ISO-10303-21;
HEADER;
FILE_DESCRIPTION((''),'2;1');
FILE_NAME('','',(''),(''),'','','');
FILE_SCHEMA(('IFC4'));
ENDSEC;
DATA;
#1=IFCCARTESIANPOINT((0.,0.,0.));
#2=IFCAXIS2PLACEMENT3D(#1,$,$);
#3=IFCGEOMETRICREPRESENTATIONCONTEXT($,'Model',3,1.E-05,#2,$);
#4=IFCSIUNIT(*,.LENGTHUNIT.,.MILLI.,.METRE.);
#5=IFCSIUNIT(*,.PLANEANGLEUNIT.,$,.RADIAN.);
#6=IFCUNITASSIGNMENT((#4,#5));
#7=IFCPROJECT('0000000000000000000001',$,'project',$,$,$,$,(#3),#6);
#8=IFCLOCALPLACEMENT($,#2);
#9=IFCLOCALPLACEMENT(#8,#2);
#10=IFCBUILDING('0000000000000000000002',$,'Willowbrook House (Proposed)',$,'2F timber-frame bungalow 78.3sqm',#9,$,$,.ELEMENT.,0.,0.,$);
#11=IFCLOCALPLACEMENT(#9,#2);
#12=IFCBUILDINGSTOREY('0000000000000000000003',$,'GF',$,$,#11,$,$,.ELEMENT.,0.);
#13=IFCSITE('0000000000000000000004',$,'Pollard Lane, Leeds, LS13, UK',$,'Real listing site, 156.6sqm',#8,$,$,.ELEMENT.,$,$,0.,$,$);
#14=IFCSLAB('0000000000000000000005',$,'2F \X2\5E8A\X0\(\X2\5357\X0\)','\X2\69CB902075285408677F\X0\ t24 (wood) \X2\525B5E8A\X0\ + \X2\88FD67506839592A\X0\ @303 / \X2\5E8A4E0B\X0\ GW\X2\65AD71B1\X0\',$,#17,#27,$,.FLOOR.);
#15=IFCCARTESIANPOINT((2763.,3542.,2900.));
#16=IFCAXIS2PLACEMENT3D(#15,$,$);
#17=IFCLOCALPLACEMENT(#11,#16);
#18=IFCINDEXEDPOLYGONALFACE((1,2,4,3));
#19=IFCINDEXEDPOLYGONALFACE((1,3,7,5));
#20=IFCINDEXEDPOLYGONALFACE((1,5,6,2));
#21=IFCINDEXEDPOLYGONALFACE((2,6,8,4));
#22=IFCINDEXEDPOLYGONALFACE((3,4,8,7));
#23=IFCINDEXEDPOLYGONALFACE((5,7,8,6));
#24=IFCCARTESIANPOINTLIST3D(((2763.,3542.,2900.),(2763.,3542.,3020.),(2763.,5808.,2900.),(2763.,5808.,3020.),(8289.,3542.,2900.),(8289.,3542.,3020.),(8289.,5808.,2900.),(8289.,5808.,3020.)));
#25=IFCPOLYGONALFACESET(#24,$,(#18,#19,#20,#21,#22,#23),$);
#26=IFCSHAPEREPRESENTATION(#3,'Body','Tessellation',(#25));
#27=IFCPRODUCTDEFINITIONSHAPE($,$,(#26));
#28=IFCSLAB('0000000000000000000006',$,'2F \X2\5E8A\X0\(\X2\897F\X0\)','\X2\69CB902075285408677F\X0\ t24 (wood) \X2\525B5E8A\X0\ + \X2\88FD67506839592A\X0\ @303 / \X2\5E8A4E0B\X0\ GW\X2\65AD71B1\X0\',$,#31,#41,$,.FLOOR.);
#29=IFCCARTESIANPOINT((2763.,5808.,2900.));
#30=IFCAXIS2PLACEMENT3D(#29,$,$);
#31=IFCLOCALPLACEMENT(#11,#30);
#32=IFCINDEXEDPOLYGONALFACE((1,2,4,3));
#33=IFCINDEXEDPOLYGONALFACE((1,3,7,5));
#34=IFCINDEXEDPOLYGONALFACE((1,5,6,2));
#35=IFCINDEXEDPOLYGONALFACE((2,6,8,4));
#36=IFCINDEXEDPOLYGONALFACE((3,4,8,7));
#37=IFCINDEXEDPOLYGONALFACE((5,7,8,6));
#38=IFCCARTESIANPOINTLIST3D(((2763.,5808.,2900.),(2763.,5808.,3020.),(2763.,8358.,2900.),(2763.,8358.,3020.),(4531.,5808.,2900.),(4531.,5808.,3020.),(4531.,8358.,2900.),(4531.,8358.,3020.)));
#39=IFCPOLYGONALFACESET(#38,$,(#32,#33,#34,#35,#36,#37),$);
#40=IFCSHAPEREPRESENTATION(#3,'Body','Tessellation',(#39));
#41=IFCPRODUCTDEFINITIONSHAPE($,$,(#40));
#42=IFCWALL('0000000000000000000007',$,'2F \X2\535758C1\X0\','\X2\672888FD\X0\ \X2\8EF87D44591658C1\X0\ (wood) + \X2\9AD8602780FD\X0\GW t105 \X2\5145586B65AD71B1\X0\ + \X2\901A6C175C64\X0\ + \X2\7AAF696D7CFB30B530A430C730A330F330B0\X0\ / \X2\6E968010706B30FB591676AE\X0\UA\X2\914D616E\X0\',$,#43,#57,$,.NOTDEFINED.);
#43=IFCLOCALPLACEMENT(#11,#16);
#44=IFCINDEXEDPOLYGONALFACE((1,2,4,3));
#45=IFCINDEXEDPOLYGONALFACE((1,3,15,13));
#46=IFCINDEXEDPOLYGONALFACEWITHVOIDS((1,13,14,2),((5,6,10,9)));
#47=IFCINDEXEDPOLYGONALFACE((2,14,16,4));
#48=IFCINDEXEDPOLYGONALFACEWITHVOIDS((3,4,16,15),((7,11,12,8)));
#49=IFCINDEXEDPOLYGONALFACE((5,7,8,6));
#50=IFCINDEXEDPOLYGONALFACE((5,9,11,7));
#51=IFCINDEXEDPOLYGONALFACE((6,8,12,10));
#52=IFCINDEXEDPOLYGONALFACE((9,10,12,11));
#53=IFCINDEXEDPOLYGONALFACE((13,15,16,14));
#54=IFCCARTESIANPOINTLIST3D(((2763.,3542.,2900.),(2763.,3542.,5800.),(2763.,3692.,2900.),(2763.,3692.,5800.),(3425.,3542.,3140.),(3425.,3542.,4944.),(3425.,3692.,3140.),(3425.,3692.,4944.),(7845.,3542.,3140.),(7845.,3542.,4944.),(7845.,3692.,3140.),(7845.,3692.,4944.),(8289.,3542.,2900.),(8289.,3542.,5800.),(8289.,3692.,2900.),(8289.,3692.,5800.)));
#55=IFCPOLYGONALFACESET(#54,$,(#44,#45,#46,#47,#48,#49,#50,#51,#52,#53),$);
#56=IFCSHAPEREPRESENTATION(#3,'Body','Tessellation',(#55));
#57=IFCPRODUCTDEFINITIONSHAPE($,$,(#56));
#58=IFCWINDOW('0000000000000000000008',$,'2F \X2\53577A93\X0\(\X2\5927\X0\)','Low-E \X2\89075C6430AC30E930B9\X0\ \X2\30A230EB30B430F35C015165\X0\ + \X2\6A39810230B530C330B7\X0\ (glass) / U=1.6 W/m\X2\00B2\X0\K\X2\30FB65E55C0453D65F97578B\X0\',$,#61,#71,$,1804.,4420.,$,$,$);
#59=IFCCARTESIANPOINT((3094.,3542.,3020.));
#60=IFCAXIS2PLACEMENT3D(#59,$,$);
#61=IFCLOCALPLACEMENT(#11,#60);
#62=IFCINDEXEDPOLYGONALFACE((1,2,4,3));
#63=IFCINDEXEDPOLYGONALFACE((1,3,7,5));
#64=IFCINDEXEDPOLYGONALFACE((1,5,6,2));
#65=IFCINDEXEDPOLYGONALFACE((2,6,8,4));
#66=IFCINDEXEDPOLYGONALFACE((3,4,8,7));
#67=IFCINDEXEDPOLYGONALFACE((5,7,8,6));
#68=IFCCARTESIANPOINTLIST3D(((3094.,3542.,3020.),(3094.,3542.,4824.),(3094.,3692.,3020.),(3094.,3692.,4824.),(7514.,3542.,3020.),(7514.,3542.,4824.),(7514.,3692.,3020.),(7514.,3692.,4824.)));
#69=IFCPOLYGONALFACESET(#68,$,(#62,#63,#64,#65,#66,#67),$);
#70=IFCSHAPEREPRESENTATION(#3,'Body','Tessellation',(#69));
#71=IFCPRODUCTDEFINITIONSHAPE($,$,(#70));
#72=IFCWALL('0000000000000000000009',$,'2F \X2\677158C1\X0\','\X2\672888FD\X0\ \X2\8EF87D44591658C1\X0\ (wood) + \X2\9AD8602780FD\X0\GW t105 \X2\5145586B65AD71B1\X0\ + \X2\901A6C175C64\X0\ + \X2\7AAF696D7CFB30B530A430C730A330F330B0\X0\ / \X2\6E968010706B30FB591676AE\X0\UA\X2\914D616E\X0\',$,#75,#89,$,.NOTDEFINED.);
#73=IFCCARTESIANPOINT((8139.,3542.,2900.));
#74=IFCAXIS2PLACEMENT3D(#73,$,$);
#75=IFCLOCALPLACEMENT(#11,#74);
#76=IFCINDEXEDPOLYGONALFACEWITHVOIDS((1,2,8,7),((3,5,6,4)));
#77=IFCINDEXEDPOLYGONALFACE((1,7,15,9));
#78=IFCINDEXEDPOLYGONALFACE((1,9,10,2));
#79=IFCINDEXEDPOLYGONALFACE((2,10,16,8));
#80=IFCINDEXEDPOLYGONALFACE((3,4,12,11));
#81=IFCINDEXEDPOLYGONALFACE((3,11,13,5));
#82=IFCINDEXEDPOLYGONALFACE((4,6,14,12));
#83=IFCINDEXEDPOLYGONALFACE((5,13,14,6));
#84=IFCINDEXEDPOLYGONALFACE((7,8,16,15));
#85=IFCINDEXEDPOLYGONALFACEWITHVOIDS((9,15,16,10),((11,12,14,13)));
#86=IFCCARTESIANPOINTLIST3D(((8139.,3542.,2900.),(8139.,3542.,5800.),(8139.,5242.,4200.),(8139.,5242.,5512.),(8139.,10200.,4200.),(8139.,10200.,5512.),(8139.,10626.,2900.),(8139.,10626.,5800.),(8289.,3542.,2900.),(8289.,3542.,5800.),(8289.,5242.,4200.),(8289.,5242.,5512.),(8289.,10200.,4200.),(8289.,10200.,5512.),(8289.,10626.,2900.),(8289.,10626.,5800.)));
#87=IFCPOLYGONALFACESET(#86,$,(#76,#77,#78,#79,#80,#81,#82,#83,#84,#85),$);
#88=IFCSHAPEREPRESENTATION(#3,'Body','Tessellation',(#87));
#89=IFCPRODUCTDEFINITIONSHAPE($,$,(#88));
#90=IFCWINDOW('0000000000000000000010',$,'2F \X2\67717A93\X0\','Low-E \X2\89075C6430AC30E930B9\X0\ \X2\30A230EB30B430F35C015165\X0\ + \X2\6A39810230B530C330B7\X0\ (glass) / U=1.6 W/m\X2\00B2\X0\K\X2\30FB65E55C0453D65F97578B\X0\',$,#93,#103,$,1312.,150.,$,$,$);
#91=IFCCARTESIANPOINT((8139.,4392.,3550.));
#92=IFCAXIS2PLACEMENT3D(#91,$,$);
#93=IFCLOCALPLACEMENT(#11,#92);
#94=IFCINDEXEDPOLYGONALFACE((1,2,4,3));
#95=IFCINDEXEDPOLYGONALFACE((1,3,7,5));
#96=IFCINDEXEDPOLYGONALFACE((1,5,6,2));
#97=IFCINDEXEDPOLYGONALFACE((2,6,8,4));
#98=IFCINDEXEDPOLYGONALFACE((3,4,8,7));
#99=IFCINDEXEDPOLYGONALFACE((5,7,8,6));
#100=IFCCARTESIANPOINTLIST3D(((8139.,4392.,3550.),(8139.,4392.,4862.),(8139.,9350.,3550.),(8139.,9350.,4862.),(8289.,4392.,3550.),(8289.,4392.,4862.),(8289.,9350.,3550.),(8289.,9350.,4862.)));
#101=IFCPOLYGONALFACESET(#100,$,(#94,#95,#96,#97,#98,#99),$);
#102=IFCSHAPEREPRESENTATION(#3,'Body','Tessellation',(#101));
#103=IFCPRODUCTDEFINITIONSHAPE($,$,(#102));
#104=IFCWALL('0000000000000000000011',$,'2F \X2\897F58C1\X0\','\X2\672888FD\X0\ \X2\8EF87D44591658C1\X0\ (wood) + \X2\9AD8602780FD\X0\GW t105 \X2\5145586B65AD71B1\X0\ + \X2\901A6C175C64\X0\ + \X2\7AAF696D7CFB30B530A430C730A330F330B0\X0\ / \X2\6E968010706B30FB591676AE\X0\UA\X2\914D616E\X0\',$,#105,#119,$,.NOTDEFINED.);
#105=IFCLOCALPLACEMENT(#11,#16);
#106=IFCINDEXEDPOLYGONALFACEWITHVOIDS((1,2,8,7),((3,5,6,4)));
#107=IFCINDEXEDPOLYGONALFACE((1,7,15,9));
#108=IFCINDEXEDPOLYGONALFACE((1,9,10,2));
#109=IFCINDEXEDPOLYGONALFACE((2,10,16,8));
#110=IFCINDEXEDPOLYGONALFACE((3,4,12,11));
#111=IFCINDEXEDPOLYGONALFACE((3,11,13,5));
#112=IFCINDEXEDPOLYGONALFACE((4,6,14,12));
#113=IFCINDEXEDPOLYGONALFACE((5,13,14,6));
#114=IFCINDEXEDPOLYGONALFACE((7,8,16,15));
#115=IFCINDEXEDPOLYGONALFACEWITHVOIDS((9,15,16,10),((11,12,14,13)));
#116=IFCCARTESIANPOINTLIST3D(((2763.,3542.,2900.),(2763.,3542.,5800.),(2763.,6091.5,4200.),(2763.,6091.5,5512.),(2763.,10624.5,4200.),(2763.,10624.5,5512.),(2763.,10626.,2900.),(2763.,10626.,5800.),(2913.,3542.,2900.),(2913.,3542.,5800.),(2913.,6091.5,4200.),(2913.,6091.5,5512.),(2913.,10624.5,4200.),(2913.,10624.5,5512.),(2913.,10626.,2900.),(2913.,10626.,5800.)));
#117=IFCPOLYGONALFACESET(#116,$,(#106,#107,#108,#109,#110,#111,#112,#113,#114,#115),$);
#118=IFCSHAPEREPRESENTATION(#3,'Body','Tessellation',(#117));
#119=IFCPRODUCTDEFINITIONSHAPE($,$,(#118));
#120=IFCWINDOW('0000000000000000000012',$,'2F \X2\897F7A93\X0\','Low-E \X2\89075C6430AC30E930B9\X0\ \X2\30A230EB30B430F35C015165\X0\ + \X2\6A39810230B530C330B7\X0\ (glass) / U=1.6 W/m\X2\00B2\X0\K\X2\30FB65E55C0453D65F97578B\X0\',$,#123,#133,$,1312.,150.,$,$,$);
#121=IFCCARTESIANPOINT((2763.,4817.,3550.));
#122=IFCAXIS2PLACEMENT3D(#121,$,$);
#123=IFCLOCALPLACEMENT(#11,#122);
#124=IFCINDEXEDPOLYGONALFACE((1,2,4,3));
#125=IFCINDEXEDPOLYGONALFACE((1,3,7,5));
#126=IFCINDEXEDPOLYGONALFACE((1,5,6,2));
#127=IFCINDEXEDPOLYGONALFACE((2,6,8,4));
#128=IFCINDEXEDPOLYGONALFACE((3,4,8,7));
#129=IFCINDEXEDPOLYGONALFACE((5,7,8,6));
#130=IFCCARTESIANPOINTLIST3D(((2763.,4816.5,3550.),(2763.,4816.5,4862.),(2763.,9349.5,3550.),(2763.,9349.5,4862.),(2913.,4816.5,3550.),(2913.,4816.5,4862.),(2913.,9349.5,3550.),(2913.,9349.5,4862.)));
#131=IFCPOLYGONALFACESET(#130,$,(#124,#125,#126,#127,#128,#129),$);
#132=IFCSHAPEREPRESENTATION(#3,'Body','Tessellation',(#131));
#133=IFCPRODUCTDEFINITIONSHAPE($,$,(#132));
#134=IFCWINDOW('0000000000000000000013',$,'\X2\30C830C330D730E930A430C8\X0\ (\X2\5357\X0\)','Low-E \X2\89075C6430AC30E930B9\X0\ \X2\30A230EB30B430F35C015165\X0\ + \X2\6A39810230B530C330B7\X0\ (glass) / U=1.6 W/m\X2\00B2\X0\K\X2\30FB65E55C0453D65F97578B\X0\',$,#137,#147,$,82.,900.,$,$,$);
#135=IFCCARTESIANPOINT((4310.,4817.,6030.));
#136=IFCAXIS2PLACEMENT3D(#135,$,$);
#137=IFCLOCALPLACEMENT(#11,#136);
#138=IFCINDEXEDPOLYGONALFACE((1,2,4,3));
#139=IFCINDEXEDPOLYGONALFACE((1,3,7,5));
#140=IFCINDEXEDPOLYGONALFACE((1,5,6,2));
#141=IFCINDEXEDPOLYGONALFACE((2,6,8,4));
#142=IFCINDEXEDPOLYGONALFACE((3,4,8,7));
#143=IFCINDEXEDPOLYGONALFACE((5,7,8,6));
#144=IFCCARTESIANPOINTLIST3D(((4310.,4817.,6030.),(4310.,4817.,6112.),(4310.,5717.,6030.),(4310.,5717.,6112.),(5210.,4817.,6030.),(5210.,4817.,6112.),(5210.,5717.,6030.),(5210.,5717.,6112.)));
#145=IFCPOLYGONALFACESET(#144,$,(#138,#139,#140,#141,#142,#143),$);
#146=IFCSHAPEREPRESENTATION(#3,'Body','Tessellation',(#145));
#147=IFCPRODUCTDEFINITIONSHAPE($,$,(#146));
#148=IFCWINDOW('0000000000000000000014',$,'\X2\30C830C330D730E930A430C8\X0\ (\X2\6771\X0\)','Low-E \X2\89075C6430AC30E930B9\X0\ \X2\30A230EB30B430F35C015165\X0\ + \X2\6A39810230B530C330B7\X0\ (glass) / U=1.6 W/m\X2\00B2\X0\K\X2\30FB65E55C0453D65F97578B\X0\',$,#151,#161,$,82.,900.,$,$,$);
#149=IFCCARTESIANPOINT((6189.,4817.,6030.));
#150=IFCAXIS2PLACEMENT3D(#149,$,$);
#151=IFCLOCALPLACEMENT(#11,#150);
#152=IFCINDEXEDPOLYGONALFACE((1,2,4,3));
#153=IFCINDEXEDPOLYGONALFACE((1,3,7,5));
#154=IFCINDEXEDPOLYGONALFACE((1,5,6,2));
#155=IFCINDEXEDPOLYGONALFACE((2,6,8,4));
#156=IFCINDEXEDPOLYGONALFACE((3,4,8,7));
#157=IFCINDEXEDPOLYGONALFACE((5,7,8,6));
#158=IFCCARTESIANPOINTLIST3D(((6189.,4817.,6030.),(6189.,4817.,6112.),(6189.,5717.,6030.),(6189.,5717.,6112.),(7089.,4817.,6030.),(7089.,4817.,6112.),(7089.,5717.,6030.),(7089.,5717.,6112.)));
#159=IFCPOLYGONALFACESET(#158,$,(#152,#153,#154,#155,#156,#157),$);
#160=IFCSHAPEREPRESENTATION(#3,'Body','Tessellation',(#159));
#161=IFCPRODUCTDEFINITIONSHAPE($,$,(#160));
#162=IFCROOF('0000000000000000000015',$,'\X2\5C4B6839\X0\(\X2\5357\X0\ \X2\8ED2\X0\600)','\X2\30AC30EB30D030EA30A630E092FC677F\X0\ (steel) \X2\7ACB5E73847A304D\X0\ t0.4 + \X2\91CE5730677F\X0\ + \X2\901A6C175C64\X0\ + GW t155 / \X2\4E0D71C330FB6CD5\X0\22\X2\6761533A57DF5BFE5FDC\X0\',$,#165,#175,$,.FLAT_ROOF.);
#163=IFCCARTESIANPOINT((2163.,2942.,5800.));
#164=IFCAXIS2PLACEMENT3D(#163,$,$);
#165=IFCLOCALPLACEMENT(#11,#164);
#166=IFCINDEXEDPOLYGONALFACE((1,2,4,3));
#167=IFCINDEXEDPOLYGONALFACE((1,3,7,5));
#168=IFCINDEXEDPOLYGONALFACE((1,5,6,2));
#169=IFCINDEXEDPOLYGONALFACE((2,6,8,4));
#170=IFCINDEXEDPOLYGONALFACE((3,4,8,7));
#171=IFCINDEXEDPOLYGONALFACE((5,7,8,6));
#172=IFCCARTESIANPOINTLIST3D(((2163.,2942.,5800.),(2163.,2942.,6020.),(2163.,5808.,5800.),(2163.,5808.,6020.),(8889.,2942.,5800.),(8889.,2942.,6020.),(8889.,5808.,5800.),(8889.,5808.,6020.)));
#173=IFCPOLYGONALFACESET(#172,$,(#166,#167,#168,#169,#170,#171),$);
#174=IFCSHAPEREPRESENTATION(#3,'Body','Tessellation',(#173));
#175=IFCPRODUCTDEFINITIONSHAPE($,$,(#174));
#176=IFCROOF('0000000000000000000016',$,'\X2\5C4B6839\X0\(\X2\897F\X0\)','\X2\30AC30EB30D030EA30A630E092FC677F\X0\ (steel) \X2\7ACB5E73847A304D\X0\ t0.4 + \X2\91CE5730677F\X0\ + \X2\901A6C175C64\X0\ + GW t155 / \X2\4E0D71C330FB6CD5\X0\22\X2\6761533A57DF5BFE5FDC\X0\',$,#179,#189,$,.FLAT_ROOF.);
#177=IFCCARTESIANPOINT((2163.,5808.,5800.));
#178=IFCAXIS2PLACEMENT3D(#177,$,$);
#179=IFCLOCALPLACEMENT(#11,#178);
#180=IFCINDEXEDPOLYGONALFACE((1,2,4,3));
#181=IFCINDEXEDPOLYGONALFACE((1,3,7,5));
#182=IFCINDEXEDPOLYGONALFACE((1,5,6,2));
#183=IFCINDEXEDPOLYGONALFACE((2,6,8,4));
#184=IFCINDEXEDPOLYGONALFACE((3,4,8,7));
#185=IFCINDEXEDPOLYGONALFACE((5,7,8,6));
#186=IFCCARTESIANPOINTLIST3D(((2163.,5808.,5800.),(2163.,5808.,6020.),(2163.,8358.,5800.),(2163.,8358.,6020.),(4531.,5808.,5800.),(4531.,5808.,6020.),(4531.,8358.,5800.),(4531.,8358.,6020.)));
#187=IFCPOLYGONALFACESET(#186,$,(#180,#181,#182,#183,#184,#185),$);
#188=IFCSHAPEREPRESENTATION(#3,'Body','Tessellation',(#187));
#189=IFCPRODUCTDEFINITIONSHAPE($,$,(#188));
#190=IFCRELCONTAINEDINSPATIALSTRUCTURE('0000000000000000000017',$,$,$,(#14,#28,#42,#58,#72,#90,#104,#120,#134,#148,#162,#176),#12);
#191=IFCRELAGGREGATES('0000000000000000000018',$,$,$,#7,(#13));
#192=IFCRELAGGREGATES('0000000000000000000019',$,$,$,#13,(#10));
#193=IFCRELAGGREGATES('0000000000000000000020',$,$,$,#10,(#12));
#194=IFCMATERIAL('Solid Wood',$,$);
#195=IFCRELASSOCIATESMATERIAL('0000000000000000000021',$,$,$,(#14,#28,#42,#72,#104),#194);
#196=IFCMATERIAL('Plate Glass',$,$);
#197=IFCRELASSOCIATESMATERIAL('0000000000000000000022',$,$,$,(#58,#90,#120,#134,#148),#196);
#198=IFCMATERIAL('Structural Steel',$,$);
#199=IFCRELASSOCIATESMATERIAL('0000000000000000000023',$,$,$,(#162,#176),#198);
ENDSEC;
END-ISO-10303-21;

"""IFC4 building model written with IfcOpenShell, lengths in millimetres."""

from ifc_helpers import new_model, si_unit, frame, frame_2d, origin, place, context, project, spatial, rectangle, extrude, material, element, fill, save


model = new_model("IFC4")

# Units and contexts
model_context = context("Model", 3, precision=1e-05, world=origin())
ifc_project = project(units=[si_unit("LENGTHUNIT", "METRE", prefix="MILLI"), si_unit("PLANEANGLEUNIT", "RADIAN")], contexts=[model_context])

# Site, building, storey
site_placement = place(None, origin())
site = spatial("IfcSite", under=ifc_project, at=site_placement, Name="Pollard Lane, Leeds, LS13, UK", ObjectType="Real listing site, 156.6sqm", CompositionType="ELEMENT", RefElevation=0.0)
building_placement = place(site_placement, origin())
building = spatial("IfcBuilding", under=site, at=building_placement, Name="Willowbrook House (Proposed)", ObjectType="2F timber-frame bungalow 78.3sqm", CompositionType="ELEMENT", ElevationOfRefHeight=0.0, ElevationOfTerrain=0.0)
storey_placement = place(building_placement, origin())
storey = spatial("IfcBuildingStorey", under=building, at=storey_placement, Name="GF", CompositionType="ELEMENT", Elevation=0.0)

# Slabs
ifc_material_1 = material(Name="Solid Wood")
slab_1_placement = place(storey_placement, frame((2763.0, 3542.0, 2900.0)))
element("IfcSlab", 1, at=slab_1_placement, inside=storey, material=ifc_material_1, Name="2F 床(南)", Description="構造用合板 t24 (wood) 剛床 + 製材根太 @303 / 床下 GW断熱", PredefinedType="FLOOR", context=model_context, shape_type="SweptSolid", body=[
    extrude(rectangle(XDim=5526.0, YDim=2266.0, at=frame_2d((2763.0, 1133.0))), frame((2763.0, 3542.0, 2900.0)), (0.0, 0.0, 1.0), 120.0),
])
slab_2_placement = place(storey_placement, frame((2763.0, 5808.0, 2900.0)))
element("IfcSlab", 2, at=slab_2_placement, inside=storey, material=ifc_material_1, Name="2F 床(西)", Description="構造用合板 t24 (wood) 剛床 + 製材根太 @303 / 床下 GW断熱", PredefinedType="FLOOR", context=model_context, shape_type="SweptSolid", body=[
    extrude(rectangle(XDim=1768.0, YDim=2550.0, at=frame_2d((884.0, 1275.0))), frame((2763.0, 5808.0, 2900.0)), (0.0, 0.0, 1.0), 120.0),
])

# Walls, openings, windows
wall_1_placement = place(storey_placement, frame((2763.0, 3542.0, 2900.0)))
wall_1 = element("IfcWall", 3, at=wall_1_placement, inside=storey, material=ifc_material_1, Name="2F 南壁", Description="木製 軸組外壁 (wood) + 高性能GW t105 充填断熱 + 通気層 + 窯業系サイディング / 準耐火・外皮UA配慮", PredefinedType="NOTDEFINED", context=model_context, shape_type="SweptSolid", body=[
    extrude(rectangle(XDim=5526.0, YDim=150.0, at=frame_2d((2763.0, 75.0))), frame((2763.0, 3542.0, 2900.0)), (0.0, 0.0, 1.0), 2900.0),
])
opening_1_placement = place(storey_placement, frame((3094.0, 3542.0, 3020.0)))
opening_1 = element("IfcOpeningElement", 4, at=opening_1_placement, cuts=wall_1, PredefinedType="NOTDEFINED", context=model_context, shape_type="SweptSolid", body=[
    extrude(rectangle(XDim=4420.0, YDim=150.0, at=frame_2d((2210.0, 75.0))), frame((3094.0, 3542.0, 3020.0)), (0.0, 0.0, 1.0), 1804.0),
])
ifc_material_2 = material(Name="Plate Glass")
window_1_placement = place(storey_placement, frame((3094.0, 3542.0, 3020.0)))
window_1 = element("IfcWindow", 5, at=window_1_placement, inside=storey, material=ifc_material_2, Name="2F 南窓(大)", Description="Low-E 複層ガラス アルゴン封入 + 樹脂サッシ (glass) / U=1.6 W/m²K・日射取得型", OverallHeight=1804.0, OverallWidth=4420.0, context=model_context, shape_type="SweptSolid", body=[
    extrude(rectangle(XDim=4420.0, YDim=150.0, at=frame_2d((2210.0, 75.0))), frame((3094.0, 3542.0, 3020.0)), (0.0, 0.0, 1.0), 1804.0),
])
fill(opening_1, window_1)
wall_2_placement = place(storey_placement, frame((8139.0, 3542.0, 2900.0)))
wall_2 = element("IfcWall", 6, at=wall_2_placement, inside=storey, material=ifc_material_1, Name="2F 東壁", Description="木製 軸組外壁 (wood) + 高性能GW t105 充填断熱 + 通気層 + 窯業系サイディング / 準耐火・外皮UA配慮", PredefinedType="NOTDEFINED", context=model_context, shape_type="SweptSolid", body=[
    extrude(rectangle(XDim=150.0, YDim=7084.0, at=frame_2d((75.0, 3542.0))), frame((8139.0, 3542.0, 2900.0)), (0.0, 0.0, 1.0), 2900.0),
])
opening_2_placement = place(storey_placement, frame((8139.0, 4392.0, 3550.0)))
opening_2 = element("IfcOpeningElement", 7, at=opening_2_placement, cuts=wall_2, PredefinedType="NOTDEFINED", context=model_context, shape_type="SweptSolid", body=[
    extrude(rectangle(XDim=150.0, YDim=4958.0, at=frame_2d((75.0, 2479.0))), frame((8139.0, 4392.0, 3550.0)), (0.0, 0.0, 1.0), 1312.0),
])
window_2_placement = place(storey_placement, frame((8139.0, 4392.0, 3550.0)))
window_2 = element("IfcWindow", 8, at=window_2_placement, inside=storey, material=ifc_material_2, Name="2F 東窓", Description="Low-E 複層ガラス アルゴン封入 + 樹脂サッシ (glass) / U=1.6 W/m²K・日射取得型", OverallHeight=1312.0, OverallWidth=150.0, context=model_context, shape_type="SweptSolid", body=[
    extrude(rectangle(XDim=150.0, YDim=4958.0, at=frame_2d((75.0, 2479.0))), frame((8139.0, 4392.0, 3550.0)), (0.0, 0.0, 1.0), 1312.0),
])
fill(opening_2, window_2)
wall_3_placement = place(storey_placement, frame((2763.0, 3542.0, 2900.0)))
wall_3 = element("IfcWall", 9, at=wall_3_placement, inside=storey, material=ifc_material_1, Name="2F 西壁", Description="木製 軸組外壁 (wood) + 高性能GW t105 充填断熱 + 通気層 + 窯業系サイディング / 準耐火・外皮UA配慮", PredefinedType="NOTDEFINED", context=model_context, shape_type="SweptSolid", body=[
    extrude(rectangle(XDim=150.0, YDim=7084.0, at=frame_2d((75.0, 3542.0))), frame((2763.0, 3542.0, 2900.0)), (0.0, 0.0, 1.0), 2900.0),
])
opening_3_placement = place(storey_placement, frame((2763.0, 4817.0, 3550.0)))
opening_3 = element("IfcOpeningElement", 10, at=opening_3_placement, cuts=wall_3, PredefinedType="NOTDEFINED", context=model_context, shape_type="SweptSolid", body=[
    extrude(rectangle(XDim=150.0, YDim=4533.0, at=frame_2d((75.0, 2266.0))), frame((2763.0, 4817.0, 3550.0)), (0.0, 0.0, 1.0), 1312.0),
])
window_3_placement = place(storey_placement, frame((2763.0, 4817.0, 3550.0)))
window_3 = element("IfcWindow", 11, at=window_3_placement, inside=storey, material=ifc_material_2, Name="2F 西窓", Description="Low-E 複層ガラス アルゴン封入 + 樹脂サッシ (glass) / U=1.6 W/m²K・日射取得型", OverallHeight=1312.0, OverallWidth=150.0, context=model_context, shape_type="SweptSolid", body=[
    extrude(rectangle(XDim=150.0, YDim=4533.0, at=frame_2d((75.0, 2266.0))), frame((2763.0, 4817.0, 3550.0)), (0.0, 0.0, 1.0), 1312.0),
])
fill(opening_3, window_3)

# Windows
window_4_placement = place(storey_placement, frame((4310.0, 4817.0, 6030.0)))
element("IfcWindow", 12, at=window_4_placement, inside=storey, material=ifc_material_2, Name="トップライト (南)", Description="Low-E 複層ガラス アルゴン封入 + 樹脂サッシ (glass) / U=1.6 W/m²K・日射取得型", OverallHeight=82.0, OverallWidth=900.0, context=model_context, shape_type="SweptSolid", body=[
    extrude(rectangle(XDim=900.0, YDim=900.0, at=frame_2d((450.0, 450.0))), frame((4310.0, 4817.0, 6030.0)), (0.0, 0.0, 1.0), 82.0),
])
window_5_placement = place(storey_placement, frame((6189.0, 4817.0, 6030.0)))
element("IfcWindow", 13, at=window_5_placement, inside=storey, material=ifc_material_2, Name="トップライト (東)", Description="Low-E 複層ガラス アルゴン封入 + 樹脂サッシ (glass) / U=1.6 W/m²K・日射取得型", OverallHeight=82.0, OverallWidth=900.0, context=model_context, shape_type="SweptSolid", body=[
    extrude(rectangle(XDim=900.0, YDim=900.0, at=frame_2d((450.0, 450.0))), frame((6189.0, 4817.0, 6030.0)), (0.0, 0.0, 1.0), 82.0),
])

# Roofs
ifc_material_3 = material(Name="Structural Steel")
roof_1_placement = place(storey_placement, frame((2163.0, 2942.0, 5800.0)))
element("IfcRoof", 14, at=roof_1_placement, inside=storey, material=ifc_material_3, Name="屋根(南 軒600)", Description="ガルバリウム鋼板 (steel) 立平葺き t0.4 + 野地板 + 通気層 + GW t155 / 不燃・法22条区域対応", PredefinedType="FLAT_ROOF", context=model_context, shape_type="SweptSolid", body=[
    extrude(rectangle(XDim=6726.0, YDim=2866.0, at=frame_2d((3363.0, 1433.0))), frame((2163.0, 2942.0, 5800.0)), (0.0, 0.0, 1.0), 220.0),
])
roof_2_placement = place(storey_placement, frame((2163.0, 5808.0, 5800.0)))
element("IfcRoof", 15, at=roof_2_placement, inside=storey, material=ifc_material_3, Name="屋根(西)", Description="ガルバリウム鋼板 (steel) 立平葺き t0.4 + 野地板 + 通気層 + GW t155 / 不燃・法22条区域対応", PredefinedType="FLAT_ROOF", context=model_context, shape_type="SweptSolid", body=[
    extrude(rectangle(XDim=2368.0, YDim=2550.0, at=frame_2d((1184.0, 1275.0))), frame((2163.0, 5808.0, 5800.0)), (0.0, 0.0, 1.0), 220.0),
])

save(model, "model.ifc")
